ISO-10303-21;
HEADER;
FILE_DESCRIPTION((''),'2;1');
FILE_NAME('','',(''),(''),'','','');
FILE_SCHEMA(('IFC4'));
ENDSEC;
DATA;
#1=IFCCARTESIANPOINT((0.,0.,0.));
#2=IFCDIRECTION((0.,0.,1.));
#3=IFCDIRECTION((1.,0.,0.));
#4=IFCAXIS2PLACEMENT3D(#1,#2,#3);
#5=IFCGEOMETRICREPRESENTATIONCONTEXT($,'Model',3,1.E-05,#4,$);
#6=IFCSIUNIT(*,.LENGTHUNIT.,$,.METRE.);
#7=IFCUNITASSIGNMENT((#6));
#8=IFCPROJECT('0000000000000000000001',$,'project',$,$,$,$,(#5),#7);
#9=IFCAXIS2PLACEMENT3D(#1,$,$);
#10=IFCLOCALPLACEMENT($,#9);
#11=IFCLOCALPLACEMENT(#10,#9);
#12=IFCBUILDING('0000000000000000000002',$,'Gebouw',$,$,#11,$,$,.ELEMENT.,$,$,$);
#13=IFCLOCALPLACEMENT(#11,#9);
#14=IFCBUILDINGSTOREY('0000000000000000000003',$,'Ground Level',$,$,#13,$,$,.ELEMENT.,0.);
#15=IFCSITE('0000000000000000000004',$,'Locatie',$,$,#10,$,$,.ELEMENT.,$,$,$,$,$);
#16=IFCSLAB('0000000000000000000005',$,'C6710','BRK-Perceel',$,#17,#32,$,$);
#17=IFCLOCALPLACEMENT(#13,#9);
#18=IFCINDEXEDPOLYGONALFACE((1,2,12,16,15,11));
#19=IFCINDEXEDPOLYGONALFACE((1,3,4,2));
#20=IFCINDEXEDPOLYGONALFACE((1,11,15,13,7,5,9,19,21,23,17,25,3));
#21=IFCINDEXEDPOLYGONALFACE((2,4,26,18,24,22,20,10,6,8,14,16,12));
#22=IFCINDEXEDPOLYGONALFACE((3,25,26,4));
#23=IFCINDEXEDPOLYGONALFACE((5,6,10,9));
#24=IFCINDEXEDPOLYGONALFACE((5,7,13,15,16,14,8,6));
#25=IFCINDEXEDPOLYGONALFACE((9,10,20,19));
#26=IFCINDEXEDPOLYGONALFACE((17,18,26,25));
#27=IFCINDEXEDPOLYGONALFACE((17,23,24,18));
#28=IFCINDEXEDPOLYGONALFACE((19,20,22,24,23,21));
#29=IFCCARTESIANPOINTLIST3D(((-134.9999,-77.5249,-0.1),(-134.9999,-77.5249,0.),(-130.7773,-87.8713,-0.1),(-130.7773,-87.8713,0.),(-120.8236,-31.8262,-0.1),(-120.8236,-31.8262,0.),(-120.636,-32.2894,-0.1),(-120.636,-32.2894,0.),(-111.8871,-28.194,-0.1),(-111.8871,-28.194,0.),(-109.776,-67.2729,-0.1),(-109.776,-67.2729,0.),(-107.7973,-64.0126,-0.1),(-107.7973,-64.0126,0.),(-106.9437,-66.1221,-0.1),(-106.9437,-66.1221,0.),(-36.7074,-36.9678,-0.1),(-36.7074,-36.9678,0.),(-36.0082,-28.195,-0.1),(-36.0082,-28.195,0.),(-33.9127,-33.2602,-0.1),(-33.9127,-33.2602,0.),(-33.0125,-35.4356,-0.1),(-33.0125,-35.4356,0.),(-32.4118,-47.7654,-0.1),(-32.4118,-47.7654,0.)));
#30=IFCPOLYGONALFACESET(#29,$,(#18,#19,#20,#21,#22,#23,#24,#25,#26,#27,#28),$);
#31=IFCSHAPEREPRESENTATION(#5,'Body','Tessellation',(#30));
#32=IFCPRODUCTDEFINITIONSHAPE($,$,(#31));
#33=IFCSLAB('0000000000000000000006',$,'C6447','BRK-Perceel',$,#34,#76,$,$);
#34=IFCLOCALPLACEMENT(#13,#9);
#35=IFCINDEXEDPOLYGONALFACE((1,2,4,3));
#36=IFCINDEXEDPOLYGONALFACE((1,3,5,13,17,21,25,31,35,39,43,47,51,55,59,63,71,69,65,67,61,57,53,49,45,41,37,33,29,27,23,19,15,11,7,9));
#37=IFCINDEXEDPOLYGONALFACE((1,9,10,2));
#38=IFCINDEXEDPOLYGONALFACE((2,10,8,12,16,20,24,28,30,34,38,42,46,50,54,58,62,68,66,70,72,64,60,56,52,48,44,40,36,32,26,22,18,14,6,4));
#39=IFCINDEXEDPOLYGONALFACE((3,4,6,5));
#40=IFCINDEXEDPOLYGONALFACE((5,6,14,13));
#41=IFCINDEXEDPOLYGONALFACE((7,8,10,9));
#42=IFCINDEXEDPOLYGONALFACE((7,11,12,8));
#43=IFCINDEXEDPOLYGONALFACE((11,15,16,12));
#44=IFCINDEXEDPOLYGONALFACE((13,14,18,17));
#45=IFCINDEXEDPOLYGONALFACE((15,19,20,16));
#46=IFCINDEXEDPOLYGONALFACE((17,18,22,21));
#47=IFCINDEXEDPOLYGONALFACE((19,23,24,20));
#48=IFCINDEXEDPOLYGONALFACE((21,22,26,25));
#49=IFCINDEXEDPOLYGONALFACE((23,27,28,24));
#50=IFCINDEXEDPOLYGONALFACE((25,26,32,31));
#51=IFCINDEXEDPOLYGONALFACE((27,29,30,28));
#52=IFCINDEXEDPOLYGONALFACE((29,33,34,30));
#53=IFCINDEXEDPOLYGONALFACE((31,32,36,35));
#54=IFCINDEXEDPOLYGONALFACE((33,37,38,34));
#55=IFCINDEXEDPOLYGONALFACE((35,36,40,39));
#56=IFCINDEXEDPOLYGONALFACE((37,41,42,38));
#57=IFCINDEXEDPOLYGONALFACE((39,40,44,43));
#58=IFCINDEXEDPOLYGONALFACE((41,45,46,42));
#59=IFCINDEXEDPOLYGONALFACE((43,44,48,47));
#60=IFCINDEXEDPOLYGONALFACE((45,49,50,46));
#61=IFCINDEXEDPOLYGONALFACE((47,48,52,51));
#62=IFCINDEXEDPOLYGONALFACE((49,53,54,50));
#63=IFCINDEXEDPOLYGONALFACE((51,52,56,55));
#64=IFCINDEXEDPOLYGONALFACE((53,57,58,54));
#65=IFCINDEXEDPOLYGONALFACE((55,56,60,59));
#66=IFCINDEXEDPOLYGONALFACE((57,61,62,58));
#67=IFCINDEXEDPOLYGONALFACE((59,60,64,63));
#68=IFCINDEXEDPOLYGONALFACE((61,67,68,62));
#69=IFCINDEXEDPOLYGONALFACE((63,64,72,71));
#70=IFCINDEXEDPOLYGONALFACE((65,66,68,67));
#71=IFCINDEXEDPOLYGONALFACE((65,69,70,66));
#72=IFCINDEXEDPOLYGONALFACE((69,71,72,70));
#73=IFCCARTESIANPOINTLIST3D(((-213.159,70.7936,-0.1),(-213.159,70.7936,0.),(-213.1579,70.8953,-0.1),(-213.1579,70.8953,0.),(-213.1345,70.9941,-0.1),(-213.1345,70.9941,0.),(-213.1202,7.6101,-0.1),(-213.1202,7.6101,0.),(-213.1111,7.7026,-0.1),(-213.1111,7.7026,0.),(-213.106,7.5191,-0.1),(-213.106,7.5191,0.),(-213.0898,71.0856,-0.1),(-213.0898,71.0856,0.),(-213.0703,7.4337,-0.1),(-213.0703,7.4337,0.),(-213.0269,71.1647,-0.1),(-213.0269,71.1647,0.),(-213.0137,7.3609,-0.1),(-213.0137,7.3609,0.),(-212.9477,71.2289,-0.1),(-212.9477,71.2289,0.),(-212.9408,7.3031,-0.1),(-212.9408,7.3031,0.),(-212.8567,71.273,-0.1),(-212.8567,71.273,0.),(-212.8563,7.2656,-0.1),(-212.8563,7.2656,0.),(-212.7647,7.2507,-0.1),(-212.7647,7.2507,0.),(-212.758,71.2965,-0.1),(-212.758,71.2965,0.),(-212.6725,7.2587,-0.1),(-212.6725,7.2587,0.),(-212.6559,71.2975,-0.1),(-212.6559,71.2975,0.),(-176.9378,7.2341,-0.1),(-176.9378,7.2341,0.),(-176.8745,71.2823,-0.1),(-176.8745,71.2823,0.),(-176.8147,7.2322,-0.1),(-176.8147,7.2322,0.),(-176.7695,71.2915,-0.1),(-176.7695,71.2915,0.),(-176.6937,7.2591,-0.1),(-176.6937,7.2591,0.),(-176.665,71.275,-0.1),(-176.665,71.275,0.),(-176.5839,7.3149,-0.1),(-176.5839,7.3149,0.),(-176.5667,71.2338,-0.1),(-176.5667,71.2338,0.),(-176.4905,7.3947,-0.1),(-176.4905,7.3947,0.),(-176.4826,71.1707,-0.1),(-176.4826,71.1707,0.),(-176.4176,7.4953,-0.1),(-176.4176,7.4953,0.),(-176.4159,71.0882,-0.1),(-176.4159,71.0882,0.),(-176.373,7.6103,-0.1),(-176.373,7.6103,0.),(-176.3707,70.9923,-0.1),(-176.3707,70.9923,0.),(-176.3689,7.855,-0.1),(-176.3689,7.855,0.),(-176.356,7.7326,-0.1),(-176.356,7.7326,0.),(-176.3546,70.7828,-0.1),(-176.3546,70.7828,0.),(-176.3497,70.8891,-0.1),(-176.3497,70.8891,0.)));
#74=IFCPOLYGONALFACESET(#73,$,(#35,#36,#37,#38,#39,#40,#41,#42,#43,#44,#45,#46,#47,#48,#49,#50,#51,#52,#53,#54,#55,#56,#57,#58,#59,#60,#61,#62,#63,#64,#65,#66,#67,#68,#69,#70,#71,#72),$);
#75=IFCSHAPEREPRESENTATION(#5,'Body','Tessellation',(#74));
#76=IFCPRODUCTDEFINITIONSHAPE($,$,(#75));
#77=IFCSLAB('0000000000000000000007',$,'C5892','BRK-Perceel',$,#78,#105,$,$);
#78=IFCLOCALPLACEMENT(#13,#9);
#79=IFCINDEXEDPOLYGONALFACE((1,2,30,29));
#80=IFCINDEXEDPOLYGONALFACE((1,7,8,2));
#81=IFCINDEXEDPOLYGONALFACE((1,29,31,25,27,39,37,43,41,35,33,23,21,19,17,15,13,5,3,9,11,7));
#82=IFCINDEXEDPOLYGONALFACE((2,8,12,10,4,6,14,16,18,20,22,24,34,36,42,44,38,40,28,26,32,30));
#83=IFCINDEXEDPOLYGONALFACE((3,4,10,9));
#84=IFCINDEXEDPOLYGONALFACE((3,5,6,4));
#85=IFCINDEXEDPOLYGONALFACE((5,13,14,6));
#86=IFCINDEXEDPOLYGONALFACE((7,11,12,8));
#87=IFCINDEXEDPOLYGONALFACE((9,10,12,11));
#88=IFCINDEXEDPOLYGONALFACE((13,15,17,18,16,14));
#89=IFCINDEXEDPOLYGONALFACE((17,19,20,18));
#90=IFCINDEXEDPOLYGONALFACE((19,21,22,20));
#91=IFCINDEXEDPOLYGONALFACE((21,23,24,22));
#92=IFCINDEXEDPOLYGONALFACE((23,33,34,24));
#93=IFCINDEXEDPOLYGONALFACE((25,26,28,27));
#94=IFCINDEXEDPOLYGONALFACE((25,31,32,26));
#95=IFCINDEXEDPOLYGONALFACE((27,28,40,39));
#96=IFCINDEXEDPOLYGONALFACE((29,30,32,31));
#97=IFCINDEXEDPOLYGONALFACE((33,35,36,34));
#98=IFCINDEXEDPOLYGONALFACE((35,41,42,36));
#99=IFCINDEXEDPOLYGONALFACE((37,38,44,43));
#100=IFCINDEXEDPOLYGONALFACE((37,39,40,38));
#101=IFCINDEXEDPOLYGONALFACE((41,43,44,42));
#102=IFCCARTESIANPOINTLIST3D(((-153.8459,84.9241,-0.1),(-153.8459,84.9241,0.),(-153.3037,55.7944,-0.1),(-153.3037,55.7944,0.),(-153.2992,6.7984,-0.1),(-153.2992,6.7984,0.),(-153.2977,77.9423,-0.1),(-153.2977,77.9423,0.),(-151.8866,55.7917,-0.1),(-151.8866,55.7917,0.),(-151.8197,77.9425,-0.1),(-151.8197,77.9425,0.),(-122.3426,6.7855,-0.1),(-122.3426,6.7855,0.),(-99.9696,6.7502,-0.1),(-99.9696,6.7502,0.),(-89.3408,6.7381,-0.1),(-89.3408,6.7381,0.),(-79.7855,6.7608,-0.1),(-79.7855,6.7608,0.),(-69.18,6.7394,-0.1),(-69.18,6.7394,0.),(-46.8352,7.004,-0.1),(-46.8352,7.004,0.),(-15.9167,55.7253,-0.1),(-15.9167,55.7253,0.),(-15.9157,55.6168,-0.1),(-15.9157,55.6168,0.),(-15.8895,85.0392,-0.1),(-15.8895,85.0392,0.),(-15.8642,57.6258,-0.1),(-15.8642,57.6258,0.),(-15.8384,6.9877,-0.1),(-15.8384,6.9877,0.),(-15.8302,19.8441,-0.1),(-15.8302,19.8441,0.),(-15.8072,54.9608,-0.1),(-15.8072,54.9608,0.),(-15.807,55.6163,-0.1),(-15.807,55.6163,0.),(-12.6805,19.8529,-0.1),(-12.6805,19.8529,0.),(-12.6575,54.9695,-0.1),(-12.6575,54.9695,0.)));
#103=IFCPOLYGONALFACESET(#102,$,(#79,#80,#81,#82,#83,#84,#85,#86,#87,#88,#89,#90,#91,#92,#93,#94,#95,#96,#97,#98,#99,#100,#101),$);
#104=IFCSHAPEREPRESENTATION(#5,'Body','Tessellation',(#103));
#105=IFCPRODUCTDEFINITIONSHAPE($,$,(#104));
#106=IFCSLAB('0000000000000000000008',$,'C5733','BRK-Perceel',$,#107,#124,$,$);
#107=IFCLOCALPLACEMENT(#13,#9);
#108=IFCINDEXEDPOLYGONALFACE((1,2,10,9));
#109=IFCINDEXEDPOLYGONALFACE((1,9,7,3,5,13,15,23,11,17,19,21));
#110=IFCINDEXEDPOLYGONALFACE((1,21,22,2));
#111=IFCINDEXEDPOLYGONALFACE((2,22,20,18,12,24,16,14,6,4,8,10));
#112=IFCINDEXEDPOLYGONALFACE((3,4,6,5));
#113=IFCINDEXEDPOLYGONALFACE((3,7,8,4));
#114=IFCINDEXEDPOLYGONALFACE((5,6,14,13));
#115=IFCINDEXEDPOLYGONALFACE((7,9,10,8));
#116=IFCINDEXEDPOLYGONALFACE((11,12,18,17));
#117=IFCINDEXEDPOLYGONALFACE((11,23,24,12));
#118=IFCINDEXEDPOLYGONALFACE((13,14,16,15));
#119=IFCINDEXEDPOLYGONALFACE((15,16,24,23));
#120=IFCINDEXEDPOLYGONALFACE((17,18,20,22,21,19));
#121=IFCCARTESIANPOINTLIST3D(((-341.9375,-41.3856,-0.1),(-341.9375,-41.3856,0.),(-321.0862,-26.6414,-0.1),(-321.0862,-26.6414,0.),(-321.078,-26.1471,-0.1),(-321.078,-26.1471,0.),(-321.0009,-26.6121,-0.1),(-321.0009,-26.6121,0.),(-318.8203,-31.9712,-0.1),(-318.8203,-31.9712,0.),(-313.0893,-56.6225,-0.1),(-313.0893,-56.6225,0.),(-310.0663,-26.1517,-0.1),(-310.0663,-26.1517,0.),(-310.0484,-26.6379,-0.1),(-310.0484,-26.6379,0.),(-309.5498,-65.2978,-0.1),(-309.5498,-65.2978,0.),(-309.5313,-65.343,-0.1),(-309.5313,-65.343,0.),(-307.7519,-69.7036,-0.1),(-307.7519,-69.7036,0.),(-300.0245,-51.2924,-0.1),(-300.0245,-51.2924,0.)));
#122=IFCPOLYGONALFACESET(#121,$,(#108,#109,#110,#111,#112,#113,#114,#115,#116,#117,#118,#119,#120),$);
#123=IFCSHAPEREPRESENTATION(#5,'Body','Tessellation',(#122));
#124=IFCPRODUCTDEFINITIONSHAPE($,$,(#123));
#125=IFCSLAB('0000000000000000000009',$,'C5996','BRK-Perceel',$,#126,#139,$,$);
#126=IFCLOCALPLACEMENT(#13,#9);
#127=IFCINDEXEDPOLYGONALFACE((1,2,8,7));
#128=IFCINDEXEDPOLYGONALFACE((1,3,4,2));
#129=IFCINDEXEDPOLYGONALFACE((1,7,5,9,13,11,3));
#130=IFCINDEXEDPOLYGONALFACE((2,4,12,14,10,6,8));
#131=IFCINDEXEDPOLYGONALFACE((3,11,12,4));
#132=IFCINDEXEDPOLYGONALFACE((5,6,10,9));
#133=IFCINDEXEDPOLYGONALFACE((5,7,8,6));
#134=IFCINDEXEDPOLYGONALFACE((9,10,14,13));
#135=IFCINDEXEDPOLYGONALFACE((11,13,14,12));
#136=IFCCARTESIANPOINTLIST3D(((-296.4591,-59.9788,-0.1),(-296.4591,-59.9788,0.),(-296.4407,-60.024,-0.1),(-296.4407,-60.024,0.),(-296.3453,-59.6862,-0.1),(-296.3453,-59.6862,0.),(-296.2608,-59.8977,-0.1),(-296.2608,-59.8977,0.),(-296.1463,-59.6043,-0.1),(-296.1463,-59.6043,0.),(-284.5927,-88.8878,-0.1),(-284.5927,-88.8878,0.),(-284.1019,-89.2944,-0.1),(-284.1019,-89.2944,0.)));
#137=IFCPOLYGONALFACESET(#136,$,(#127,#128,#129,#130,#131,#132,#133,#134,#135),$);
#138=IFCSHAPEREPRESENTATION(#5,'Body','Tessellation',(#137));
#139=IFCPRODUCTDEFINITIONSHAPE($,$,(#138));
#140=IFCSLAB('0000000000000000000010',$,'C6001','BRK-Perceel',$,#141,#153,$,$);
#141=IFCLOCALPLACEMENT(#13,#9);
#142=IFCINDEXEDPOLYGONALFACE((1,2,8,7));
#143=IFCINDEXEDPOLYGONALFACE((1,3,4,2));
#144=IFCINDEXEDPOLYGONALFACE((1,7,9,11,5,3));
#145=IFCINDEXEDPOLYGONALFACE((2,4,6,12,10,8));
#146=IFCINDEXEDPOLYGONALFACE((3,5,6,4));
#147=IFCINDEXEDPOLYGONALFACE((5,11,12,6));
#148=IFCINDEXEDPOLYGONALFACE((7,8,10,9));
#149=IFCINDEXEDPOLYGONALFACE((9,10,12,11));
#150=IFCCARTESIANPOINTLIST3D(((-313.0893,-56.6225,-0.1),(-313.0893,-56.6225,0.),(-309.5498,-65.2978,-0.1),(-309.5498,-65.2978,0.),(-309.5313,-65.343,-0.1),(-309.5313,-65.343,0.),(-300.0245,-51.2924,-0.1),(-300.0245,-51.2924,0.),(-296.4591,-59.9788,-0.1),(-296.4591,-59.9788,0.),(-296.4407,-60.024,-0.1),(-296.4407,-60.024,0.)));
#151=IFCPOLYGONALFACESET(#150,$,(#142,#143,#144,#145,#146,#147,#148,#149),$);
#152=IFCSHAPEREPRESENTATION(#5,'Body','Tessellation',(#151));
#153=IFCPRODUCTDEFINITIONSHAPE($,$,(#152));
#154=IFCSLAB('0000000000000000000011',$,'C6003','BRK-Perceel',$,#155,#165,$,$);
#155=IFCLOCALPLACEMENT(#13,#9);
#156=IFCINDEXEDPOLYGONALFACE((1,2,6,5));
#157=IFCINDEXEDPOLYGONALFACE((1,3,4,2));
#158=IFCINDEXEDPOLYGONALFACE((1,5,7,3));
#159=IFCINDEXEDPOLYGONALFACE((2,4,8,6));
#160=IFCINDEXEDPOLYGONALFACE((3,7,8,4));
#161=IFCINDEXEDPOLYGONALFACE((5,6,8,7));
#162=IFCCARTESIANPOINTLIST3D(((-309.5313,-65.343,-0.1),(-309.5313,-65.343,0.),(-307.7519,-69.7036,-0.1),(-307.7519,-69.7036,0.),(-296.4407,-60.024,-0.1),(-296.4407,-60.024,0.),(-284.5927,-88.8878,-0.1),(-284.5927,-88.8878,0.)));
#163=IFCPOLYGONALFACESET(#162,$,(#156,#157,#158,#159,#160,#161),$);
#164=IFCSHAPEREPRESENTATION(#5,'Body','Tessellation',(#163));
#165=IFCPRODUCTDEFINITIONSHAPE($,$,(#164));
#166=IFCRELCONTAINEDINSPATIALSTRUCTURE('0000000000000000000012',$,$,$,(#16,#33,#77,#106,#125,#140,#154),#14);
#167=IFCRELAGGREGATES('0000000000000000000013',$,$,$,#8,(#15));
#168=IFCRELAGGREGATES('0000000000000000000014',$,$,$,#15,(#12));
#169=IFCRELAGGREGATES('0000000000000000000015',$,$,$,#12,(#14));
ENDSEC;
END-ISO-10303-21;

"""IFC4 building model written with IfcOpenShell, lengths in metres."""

from ifc_helpers import new_model, si_unit, frame, origin, origin_with_axes, place, context, project, spatial, polyline, outline, extrude, element, save


model = new_model("IFC4")

# Units and contexts
model_context = context("Model", 3, precision=1e-05, world=origin_with_axes())
ifc_project = project(units=[si_unit("LENGTHUNIT", "METRE")], contexts=[model_context])

# Site, building, storey
site_placement = place(None, origin())
site = spatial("IfcSite", under=ifc_project, at=site_placement, Name="Locatie", CompositionType="ELEMENT")
building_placement = place(site_placement, origin())
building = spatial("IfcBuilding", under=site, at=building_placement, Name="Gebouw", CompositionType="ELEMENT")
storey_placement = place(building_placement, origin())
storey = spatial("IfcBuildingStorey", under=building, at=storey_placement, Name="Ground Level", CompositionType="ELEMENT", Elevation=0.0)

# Slabs
slab_1_placement = place(storey_placement, origin())
element("IfcSlab", 1, at=slab_1_placement, inside=storey, Name="C6710", Description="BRK-Perceel", context=model_context, shape_type="SweptSolid", body=[
    extrude(outline(polyline([(-107.7973, -64.0126), (-120.636, -32.2894), (-120.8236, -31.8262), (-111.8871, -28.194), (-36.0082, -28.195), (-33.9127, -33.2602), (-33.0125, -35.4356), (-36.7074, -36.9678), (-32.4118, -47.7654), (-130.7773, -87.8713), (-134.9999, -77.5249), (-109.776, -67.2729), (-106.9437, -66.1221), (-107.7973, -64.0126)])), frame((0.0, 0.0, -0.1), z_axis=(0.0, 0.0, 1.0), x_axis=(1.0, 0.0, 0.0)), (0.0, 0.0, 1.0), 0.1),
])
slab_2_placement = place(storey_placement, origin())
element("IfcSlab", 2, at=slab_2_placement, inside=storey, Name="C6447", Description="BRK-Perceel", context=model_context, shape_type="SweptSolid", body=[
    extrude(outline(polyline([(-176.3689, 7.855), (-176.356, 7.7326), (-176.373, 7.6103), (-176.4176, 7.4953), (-176.4905, 7.3947), (-176.5839, 7.3149), (-176.6937, 7.2591), (-176.8147, 7.2322), (-176.9378, 7.2341), (-212.6725, 7.2587), (-212.7647, 7.2507), (-212.8563, 7.2656), (-212.9408, 7.3031), (-213.0137, 7.3609), (-213.0703, 7.4337), (-213.106, 7.5191), (-213.1202, 7.6101), (-213.1111, 7.7026), (-213.159, 70.7936), (-213.1579, 70.8953), (-213.1345, 70.9941), (-213.0898, 71.0856), (-213.0269, 71.1647), (-212.9477, 71.2289), (-212.8567, 71.273), (-212.758, 71.2965), (-212.6559, 71.2975), (-176.8745, 71.2823), (-176.7695, 71.2915), (-176.665, 71.275), (-176.5667, 71.2338), (-176.4826, 71.1707), (-176.4159, 71.0882), (-176.3707, 70.9923), (-176.3497, 70.8891), (-176.3546, 70.7828), (-176.3689, 7.855)])), frame((0.0, 0.0, -0.1), z_axis=(0.0, 0.0, 1.0), x_axis=(1.0, 0.0, 0.0)), (0.0, 0.0, 1.0), 0.1),
])
slab_3_placement = place(storey_placement, origin())
element("IfcSlab", 3, at=slab_3_placement, inside=storey, Name="C5892", Description="BRK-Perceel", context=model_context, shape_type="SweptSolid", body=[
    extrude(outline(polyline([(-12.6805, 19.8529), (-15.8302, 19.8441), (-15.8384, 6.9877), (-46.8352, 7.004), (-69.18, 6.7394), (-79.7855, 6.7608), (-89.3408, 6.7381), (-99.9696, 6.7502), (-122.3426, 6.7855), (-153.2992, 6.7984), (-153.3037, 55.7944), (-151.8866, 55.7917), (-151.8197, 77.9425), (-153.2977, 77.9423), (-153.8459, 84.9241), (-15.8895, 85.0392), (-15.8642, 57.6258), (-15.9167, 55.7253), (-15.9157, 55.6168), (-15.807, 55.6163), (-15.8072, 54.9608), (-12.6575, 54.9695), (-12.6805, 19.8529)])), frame((0.0, 0.0, -0.1), z_axis=(0.0, 0.0, 1.0), x_axis=(1.0, 0.0, 0.0)), (0.0, 0.0, 1.0), 0.1),
])
slab_4_placement = place(storey_placement, origin())
element("IfcSlab", 4, at=slab_4_placement, inside=storey, Name="C5733", Description="BRK-Perceel", context=model_context, shape_type="SweptSolid", body=[
    extrude(outline(polyline([(-318.8203, -31.9712), (-321.0009, -26.6121), (-321.0862, -26.6414), (-321.078, -26.1471), (-310.0663, -26.1517), (-310.0484, -26.6379), (-300.0245, -51.2924), (-313.0893, -56.6225), (-309.5498, -65.2978), (-309.5313, -65.343), (-307.7519, -69.7036), (-341.9375, -41.3856), (-318.8203, -31.9712)])), frame((0.0, 0.0, -0.1), z_axis=(0.0, 0.0, 1.0), x_axis=(1.0, 0.0, 0.0)), (0.0, 0.0, 1.0), 0.1),
])
slab_5_placement = place(storey_placement, origin())
element("IfcSlab", 5, at=slab_5_placement, inside=storey, Name="C5996", Description="BRK-Perceel", context=model_context, shape_type="SweptSolid", body=[
    extrude(outline(polyline([(-296.4407, -60.024), (-296.4591, -59.9788), (-296.2608, -59.8977), (-296.3453, -59.6862), (-296.1463, -59.6043), (-284.1019, -89.2944), (-284.5927, -88.8878), (-296.4407, -60.024)])), frame((0.0, 0.0, -0.1), z_axis=(0.0, 0.0, 1.0), x_axis=(1.0, 0.0, 0.0)), (0.0, 0.0, 1.0), 0.1),
])
slab_6_placement = place(storey_placement, origin())
element("IfcSlab", 6, at=slab_6_placement, inside=storey, Name="C6001", Description="BRK-Perceel", context=model_context, shape_type="SweptSolid", body=[
    extrude(outline(polyline([(-309.5313, -65.343), (-309.5498, -65.2978), (-313.0893, -56.6225), (-300.0245, -51.2924), (-296.4591, -59.9788), (-296.4407, -60.024), (-309.5313, -65.343)])), frame((0.0, 0.0, -0.1), z_axis=(0.0, 0.0, 1.0), x_axis=(1.0, 0.0, 0.0)), (0.0, 0.0, 1.0), 0.1),
])
slab_7_placement = place(storey_placement, origin())
element("IfcSlab", 7, at=slab_7_placement, inside=storey, Name="C6003", Description="BRK-Perceel", context=model_context, shape_type="SweptSolid", body=[
    extrude(outline(polyline([(-309.5313, -65.343), (-296.4407, -60.024), (-284.5927, -88.8878), (-307.7519, -69.7036), (-309.5313, -65.343)])), frame((0.0, 0.0, -0.1), z_axis=(0.0, 0.0, 1.0), x_axis=(1.0, 0.0, 0.0)), (0.0, 0.0, 1.0), 0.1),
])

save(model, "model.ifc")
